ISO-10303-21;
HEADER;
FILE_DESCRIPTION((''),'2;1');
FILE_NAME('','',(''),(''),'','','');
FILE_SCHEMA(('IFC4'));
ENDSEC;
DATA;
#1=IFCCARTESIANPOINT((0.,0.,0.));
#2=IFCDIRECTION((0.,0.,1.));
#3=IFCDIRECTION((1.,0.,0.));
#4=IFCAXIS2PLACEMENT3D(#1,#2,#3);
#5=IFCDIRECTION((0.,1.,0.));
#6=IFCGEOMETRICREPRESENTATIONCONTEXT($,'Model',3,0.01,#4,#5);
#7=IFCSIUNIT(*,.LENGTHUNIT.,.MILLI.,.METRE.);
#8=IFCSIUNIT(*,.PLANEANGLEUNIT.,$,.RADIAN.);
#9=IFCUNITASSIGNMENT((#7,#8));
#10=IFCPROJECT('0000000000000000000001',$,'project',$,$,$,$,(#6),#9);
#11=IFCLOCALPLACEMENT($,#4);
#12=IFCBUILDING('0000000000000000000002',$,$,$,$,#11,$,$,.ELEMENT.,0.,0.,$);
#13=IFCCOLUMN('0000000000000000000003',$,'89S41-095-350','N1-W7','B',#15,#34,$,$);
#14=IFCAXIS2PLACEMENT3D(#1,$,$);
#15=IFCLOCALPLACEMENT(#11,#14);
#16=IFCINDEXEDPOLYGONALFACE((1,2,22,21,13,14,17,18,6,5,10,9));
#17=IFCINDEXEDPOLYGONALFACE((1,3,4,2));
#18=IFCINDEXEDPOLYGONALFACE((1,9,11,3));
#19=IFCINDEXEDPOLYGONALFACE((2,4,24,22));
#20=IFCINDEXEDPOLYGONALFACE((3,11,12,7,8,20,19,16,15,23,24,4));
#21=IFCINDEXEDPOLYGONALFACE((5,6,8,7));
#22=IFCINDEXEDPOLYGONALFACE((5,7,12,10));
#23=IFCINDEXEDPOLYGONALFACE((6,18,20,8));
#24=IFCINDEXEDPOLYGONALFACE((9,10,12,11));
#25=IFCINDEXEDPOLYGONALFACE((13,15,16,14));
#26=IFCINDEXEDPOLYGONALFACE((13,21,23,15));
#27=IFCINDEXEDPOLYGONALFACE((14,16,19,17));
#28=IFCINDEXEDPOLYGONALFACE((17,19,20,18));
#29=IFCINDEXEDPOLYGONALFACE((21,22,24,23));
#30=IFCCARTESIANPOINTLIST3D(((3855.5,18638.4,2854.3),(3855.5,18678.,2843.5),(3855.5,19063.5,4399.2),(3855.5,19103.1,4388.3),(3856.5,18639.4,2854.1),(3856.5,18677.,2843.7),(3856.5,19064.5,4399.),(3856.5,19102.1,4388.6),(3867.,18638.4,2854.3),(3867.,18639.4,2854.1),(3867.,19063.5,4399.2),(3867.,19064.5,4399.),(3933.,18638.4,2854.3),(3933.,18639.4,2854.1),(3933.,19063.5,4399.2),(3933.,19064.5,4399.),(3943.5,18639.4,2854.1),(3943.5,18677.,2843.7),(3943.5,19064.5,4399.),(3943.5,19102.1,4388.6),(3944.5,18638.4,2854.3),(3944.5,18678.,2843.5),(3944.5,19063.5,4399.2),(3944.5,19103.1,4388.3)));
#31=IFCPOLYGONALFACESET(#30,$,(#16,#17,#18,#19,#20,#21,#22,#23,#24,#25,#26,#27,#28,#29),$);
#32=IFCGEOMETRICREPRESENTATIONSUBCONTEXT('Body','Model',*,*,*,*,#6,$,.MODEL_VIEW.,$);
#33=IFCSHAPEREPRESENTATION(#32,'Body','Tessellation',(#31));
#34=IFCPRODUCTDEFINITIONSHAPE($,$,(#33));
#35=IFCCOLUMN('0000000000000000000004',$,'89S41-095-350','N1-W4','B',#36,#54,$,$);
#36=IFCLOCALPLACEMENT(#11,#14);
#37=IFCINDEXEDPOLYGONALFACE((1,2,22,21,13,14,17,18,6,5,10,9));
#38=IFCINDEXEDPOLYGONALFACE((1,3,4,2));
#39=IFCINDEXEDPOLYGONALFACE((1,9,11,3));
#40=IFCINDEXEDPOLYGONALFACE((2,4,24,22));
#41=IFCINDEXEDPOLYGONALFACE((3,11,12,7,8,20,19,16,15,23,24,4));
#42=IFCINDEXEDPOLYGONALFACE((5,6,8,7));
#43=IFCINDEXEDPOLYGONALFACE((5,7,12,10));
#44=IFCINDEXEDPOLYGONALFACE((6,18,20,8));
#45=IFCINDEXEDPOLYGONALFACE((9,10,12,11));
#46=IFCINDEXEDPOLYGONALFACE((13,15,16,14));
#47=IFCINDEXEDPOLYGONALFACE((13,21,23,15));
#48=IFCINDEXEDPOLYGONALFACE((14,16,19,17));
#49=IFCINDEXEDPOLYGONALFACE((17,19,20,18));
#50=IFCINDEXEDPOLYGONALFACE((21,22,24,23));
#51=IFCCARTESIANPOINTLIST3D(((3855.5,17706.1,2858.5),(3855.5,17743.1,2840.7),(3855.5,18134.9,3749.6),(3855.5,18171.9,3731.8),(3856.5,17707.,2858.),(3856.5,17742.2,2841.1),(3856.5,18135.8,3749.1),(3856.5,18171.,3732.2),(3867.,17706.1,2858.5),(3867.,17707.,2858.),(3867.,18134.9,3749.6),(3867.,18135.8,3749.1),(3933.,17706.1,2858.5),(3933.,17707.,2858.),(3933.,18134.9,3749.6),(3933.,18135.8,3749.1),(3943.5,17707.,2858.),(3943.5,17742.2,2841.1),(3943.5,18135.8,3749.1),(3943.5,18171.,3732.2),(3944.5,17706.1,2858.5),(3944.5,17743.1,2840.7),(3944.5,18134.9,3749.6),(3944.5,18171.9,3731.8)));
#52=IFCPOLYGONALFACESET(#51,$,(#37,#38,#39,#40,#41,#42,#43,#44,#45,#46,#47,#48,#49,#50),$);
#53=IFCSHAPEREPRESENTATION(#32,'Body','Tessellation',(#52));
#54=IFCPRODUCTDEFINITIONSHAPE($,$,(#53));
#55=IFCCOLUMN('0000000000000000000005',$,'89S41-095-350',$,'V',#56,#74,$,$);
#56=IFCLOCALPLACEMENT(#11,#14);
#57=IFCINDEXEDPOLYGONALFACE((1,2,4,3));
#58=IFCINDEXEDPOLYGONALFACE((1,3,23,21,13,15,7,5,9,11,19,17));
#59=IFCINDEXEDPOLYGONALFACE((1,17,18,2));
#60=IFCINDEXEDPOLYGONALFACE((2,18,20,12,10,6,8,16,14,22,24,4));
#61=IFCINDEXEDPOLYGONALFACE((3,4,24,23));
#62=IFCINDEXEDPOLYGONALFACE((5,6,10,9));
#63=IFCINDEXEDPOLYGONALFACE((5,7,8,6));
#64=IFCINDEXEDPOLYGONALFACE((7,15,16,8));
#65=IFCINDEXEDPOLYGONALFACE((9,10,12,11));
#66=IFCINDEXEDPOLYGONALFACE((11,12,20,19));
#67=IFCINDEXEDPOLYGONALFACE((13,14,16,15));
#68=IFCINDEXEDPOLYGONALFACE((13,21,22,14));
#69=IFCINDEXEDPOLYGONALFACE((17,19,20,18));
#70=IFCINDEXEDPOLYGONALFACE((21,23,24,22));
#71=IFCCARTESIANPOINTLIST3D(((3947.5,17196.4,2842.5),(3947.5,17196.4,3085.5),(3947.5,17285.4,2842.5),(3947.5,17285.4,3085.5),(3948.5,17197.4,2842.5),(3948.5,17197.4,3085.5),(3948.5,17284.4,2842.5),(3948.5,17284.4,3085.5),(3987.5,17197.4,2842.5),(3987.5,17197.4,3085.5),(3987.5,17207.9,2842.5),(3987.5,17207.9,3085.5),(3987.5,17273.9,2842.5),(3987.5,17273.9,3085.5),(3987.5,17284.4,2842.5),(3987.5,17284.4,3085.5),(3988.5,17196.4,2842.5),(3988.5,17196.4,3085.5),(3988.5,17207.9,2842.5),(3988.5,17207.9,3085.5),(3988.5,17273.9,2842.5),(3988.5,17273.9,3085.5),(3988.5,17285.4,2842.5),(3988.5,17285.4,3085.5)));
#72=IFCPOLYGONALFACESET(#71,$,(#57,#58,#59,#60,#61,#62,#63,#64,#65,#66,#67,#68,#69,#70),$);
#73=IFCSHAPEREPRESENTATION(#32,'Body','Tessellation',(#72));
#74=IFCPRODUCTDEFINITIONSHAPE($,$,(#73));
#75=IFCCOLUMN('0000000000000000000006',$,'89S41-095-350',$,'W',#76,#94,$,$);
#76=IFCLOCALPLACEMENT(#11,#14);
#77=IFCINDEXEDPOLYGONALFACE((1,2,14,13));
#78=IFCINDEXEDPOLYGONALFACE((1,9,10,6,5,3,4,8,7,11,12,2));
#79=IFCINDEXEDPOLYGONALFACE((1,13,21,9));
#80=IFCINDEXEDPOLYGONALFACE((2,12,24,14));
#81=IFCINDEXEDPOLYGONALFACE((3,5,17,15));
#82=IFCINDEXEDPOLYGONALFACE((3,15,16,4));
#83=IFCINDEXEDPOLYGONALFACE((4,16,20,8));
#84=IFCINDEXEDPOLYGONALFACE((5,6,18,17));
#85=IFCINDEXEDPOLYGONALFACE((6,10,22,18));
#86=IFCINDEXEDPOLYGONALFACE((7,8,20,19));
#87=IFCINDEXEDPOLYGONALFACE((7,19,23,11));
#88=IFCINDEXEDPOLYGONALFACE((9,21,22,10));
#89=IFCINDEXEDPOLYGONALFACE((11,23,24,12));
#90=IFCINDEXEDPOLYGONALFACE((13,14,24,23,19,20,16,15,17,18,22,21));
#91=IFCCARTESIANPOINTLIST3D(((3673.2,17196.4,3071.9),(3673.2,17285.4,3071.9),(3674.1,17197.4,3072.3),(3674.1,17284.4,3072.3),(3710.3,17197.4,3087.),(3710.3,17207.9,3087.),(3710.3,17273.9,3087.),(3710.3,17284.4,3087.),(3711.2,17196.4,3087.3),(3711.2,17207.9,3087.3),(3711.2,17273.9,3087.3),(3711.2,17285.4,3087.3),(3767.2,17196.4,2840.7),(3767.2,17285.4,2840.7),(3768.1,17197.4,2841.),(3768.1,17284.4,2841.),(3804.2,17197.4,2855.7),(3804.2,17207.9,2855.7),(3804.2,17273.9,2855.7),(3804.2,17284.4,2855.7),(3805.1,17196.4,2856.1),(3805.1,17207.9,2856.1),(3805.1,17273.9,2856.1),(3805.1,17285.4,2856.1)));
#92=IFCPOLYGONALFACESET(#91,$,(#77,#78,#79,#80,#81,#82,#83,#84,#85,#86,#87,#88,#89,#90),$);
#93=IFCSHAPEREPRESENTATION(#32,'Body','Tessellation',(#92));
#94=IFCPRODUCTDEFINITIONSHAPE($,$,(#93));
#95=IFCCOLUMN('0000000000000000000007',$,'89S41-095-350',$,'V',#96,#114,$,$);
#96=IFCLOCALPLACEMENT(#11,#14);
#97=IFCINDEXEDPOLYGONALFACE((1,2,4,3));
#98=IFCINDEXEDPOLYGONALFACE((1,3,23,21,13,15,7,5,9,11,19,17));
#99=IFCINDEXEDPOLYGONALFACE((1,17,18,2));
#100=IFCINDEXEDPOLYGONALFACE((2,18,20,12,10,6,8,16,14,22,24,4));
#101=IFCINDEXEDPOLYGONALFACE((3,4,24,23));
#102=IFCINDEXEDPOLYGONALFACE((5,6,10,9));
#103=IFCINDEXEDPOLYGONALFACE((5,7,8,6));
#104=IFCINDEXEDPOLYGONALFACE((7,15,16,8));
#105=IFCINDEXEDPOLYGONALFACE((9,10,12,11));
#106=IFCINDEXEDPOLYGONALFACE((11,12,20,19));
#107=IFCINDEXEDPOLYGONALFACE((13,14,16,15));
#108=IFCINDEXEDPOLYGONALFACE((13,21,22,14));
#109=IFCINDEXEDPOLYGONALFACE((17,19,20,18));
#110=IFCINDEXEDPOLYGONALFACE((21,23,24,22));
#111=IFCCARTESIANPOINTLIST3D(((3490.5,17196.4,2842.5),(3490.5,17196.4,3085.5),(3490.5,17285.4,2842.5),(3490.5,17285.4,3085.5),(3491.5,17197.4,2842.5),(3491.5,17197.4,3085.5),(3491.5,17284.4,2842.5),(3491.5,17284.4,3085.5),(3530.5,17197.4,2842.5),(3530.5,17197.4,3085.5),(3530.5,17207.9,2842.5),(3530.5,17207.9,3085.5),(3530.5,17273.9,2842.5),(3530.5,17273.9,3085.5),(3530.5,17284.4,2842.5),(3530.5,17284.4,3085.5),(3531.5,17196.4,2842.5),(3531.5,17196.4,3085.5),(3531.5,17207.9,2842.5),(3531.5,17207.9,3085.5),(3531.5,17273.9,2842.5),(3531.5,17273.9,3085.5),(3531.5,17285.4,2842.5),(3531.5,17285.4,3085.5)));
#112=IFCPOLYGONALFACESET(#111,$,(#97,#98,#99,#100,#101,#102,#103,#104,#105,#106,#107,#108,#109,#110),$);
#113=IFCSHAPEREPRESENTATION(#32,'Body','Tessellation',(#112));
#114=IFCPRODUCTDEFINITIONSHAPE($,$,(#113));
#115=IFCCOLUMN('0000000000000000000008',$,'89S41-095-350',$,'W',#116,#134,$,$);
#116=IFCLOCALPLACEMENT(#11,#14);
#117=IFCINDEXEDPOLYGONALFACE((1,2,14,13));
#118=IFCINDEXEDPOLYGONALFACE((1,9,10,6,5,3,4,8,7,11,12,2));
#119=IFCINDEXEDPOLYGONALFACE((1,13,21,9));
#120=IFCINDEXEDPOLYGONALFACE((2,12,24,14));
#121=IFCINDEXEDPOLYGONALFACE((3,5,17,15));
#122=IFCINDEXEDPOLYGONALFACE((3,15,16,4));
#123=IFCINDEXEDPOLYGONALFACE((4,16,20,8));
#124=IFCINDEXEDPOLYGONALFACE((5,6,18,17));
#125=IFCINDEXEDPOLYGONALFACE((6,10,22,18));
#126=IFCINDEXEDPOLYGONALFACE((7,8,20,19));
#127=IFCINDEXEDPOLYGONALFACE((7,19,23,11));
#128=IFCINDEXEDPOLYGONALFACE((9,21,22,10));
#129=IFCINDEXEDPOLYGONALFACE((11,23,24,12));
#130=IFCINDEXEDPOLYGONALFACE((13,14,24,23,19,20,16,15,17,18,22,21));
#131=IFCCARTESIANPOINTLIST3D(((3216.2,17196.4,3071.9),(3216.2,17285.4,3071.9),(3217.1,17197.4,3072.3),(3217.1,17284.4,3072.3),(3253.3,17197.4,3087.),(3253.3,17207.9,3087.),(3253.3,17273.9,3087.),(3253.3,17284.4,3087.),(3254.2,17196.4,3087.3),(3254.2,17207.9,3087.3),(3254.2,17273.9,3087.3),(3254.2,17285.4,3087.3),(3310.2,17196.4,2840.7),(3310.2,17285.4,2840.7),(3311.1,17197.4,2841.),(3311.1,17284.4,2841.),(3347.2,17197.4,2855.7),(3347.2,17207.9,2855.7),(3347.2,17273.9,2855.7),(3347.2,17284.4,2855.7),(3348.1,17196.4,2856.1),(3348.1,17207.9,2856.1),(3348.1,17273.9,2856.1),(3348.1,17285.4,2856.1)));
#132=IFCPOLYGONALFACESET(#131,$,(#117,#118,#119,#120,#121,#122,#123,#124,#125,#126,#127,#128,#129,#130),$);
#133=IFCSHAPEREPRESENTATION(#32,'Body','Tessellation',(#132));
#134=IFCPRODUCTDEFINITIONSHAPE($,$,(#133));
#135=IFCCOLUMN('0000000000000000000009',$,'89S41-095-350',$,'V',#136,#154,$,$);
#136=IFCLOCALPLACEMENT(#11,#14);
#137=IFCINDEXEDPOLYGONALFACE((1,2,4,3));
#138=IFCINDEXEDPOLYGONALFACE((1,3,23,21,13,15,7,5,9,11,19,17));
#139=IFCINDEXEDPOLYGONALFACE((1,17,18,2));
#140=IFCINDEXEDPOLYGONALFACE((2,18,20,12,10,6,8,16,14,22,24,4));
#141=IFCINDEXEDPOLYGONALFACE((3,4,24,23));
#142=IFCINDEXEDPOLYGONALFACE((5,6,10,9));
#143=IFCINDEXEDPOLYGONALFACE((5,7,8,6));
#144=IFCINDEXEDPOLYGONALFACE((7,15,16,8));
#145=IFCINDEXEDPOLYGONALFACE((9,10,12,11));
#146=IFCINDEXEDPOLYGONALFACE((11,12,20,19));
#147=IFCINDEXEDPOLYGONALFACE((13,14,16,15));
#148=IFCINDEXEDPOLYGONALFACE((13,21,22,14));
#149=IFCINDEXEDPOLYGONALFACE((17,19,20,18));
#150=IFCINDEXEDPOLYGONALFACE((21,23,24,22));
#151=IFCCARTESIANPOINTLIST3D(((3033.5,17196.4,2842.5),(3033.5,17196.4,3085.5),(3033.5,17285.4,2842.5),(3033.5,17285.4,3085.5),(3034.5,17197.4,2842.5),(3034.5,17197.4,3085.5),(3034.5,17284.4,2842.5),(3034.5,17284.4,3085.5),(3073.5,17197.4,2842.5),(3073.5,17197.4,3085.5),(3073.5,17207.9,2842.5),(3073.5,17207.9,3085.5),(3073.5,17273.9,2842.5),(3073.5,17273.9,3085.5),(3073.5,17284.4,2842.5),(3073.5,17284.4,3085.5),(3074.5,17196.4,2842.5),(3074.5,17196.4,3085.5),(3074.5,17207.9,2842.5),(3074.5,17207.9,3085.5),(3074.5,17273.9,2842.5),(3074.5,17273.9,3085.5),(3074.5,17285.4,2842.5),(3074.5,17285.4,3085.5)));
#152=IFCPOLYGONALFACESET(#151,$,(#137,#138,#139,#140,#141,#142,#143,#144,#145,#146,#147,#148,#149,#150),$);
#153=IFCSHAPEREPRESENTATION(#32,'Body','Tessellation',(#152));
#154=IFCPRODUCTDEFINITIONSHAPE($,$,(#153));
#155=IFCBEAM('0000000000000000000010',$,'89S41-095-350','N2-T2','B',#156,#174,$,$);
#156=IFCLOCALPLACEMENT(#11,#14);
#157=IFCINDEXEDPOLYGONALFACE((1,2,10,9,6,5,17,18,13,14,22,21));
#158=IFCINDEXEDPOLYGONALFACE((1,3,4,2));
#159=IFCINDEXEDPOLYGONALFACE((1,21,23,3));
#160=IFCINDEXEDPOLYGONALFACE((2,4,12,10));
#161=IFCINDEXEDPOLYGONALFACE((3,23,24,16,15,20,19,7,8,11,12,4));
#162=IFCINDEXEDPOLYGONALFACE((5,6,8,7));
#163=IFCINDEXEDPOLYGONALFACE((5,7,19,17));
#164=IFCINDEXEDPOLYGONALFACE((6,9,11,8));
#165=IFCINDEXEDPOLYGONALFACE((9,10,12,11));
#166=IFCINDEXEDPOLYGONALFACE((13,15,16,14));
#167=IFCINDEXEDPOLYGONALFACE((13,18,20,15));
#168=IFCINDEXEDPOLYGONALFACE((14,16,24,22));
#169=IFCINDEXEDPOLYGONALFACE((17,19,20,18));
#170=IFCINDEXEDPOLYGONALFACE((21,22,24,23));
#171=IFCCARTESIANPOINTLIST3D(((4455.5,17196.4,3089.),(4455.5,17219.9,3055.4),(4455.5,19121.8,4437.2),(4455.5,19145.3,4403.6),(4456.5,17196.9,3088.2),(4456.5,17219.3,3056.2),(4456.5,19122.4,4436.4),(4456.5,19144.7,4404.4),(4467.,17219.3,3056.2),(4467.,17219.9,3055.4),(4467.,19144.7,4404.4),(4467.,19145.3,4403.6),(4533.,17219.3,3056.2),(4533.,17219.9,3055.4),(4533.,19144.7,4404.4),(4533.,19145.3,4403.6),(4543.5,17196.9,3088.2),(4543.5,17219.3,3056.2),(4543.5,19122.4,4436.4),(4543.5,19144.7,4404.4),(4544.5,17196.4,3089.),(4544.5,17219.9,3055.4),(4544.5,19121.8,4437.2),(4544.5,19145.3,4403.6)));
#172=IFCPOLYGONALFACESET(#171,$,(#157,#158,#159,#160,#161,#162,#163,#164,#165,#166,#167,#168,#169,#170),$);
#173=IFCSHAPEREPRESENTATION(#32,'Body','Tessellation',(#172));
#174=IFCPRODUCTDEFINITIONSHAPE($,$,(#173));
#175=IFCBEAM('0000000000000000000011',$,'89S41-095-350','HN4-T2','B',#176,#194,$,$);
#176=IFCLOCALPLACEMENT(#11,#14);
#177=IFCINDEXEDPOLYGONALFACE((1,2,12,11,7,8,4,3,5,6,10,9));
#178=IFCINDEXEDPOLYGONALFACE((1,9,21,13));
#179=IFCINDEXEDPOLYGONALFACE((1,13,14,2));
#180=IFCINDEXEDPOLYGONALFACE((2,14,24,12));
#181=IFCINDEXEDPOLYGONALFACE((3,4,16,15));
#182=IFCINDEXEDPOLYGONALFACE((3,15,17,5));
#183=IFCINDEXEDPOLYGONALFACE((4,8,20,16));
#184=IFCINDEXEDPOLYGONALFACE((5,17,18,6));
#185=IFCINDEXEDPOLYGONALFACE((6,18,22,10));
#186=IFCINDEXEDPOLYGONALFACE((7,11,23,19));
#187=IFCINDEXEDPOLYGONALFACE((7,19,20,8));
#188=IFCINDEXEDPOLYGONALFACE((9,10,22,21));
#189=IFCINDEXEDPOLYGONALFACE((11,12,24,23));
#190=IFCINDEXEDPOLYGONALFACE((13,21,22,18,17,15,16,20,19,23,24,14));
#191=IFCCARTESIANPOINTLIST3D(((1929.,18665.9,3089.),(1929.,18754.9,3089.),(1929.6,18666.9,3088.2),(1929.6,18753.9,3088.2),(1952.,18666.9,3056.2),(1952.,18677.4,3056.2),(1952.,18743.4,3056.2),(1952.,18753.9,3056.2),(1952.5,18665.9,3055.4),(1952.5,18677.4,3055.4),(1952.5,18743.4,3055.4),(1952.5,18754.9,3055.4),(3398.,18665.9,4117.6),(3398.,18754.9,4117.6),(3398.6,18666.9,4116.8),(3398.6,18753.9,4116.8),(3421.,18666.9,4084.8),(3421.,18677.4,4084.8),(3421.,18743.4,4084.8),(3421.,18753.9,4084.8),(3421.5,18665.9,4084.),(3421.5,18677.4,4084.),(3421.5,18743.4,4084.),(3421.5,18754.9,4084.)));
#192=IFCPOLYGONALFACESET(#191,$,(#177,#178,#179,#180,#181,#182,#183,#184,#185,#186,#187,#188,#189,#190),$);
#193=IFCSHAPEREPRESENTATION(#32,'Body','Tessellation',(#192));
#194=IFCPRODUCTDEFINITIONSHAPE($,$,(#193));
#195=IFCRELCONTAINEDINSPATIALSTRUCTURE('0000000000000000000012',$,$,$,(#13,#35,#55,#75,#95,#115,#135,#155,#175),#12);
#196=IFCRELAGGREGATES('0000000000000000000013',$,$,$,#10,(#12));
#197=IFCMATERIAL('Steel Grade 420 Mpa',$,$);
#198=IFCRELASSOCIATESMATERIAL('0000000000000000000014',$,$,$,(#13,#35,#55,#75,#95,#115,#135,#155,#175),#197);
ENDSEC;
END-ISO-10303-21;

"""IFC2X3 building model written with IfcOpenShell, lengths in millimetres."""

from ifc_helpers import new_model, si_unit, direction, frame, origin, origin_with_axes, origin_2d_with_axis, place, context, subcontext, project, spatial, c_section, extrude, source, transform, mapped, material, element, save


model = new_model("IFC2X3")

# Units and contexts
model_context = context("Model", 3, precision=0.01, world=origin_with_axes(), true_north=direction((0.0, 1.0, 0.0)))
body_context = subcontext(model_context, "Body", "Model", "MODEL_VIEW")
ifc_project = project(units=[si_unit("LENGTHUNIT", "METRE", prefix="MILLI"), si_unit("PLANEANGLEUNIT", "RADIAN")], contexts=[model_context])

# Building
building_placement = place(None, origin_with_axes())
building = spatial("IfcBuilding", under=ifc_project, at=building_placement, CompositionType="ELEMENT", ElevationOfRefHeight=0.0, ElevationOfTerrain=0.0)

# Columns
ifc_material = material(Name="Steel Grade 420 Mpa")
shared_shape_1 = source(origin(), body_context, "Body", "SweptSolid", [
    extrude(c_section(Depth=89.0, Width=41.0, WallThickness=1.0, Girth=11.5, at=origin_2d_with_axis()), origin_with_axes(), (0.0, 0.0, 1.0), 1602.3),
])
column_1_placement = place(None, frame((3900.0, 19083.3, 4393.8), z_axis=(0.0, -0.265305, -0.964165), x_axis=(0.0, -0.964165, 0.265305)))
element("IfcColumn", 1, at=column_1_placement, inside=building, material=ifc_material, Name="89S41-095-350", Description="N1-W7", ObjectType="B", context=body_context, shape_type="MappedRepresentation", body=[
    mapped(shared_shape_1, transform((0.0, 0.0, 0.0), scale=1.0)),
])
shared_shape_2 = source(origin(), body_context, "Body", "SweptSolid", [
    extrude(c_section(Depth=89.0, Width=41.0, WallThickness=1.0, Girth=11.5, at=origin_2d_with_axis()), origin_with_axes(), (0.0, 0.0, 1.0), 988.9),
])
column_2_placement = place(None, frame((3900.0, 18153.4, 3740.7), z_axis=(0.0, -0.433624, -0.901094), x_axis=(0.0, -0.901094, 0.433624)))
element("IfcColumn", 2, at=column_2_placement, inside=building, material=ifc_material, Name="89S41-095-350", Description="N1-W4", ObjectType="B", context=body_context, shape_type="MappedRepresentation", body=[
    mapped(shared_shape_2, transform((0.0, 0.0, 0.0), scale=1.0)),
])
shared_shape_3 = source(origin(), body_context, "Body", "SweptSolid", [
    extrude(c_section(Depth=89.0, Width=41.0, WallThickness=1.0, Girth=11.5, at=origin_2d_with_axis()), origin_with_axes(), (0.0, 0.0, 1.0), 243.0),
])
column_3_placement = place(None, frame((3968.0, 17240.9, 3085.5), z_axis=(0.0, 0.0, -1.0), x_axis=(1.0, 0.0, 0.0)))
element("IfcColumn", 3, at=column_3_placement, inside=building, material=ifc_material, Name="89S41-095-350", ObjectType="V", context=body_context, shape_type="MappedRepresentation", body=[
    mapped(shared_shape_3, transform((0.0, 0.0, 0.0), scale=1.0)),
])
shared_shape_4 = source(origin(), body_context, "Body", "SweptSolid", [
    extrude(c_section(Depth=89.0, Width=41.0, WallThickness=1.0, Girth=11.5, at=origin_2d_with_axis()), origin_with_axes(), (0.0, 0.0, 1.0), 249.6),
])
column_4_placement = place(None, frame((3692.2, 17240.9, 3079.6), z_axis=(0.376416, 0.0, -0.926451), x_axis=(0.926451, 0.0, 0.376416)))
element("IfcColumn", 4, at=column_4_placement, inside=building, material=ifc_material, Name="89S41-095-350", ObjectType="W", context=body_context, shape_type="MappedRepresentation", body=[
    mapped(shared_shape_4, transform((0.0, 0.0, 0.0), scale=1.0)),
])
shared_shape_5 = source(origin(), body_context, "Body", "SweptSolid", [
    extrude(c_section(Depth=89.0, Width=41.0, WallThickness=1.0, Girth=11.5, at=origin_2d_with_axis()), origin_with_axes(), (0.0, 0.0, 1.0), 243.0),
])
column_5_placement = place(None, frame((3511.0, 17240.9, 3085.5), z_axis=(0.0, 0.0, -1.0), x_axis=(1.0, 0.0, 0.0)))
element("IfcColumn", 5, at=column_5_placement, inside=building, material=ifc_material, Name="89S41-095-350", ObjectType="V", context=body_context, shape_type="MappedRepresentation", body=[
    mapped(shared_shape_5, transform((0.0, 0.0, 0.0), scale=1.0)),
])
shared_shape_6 = source(origin(), body_context, "Body", "SweptSolid", [
    extrude(c_section(Depth=89.0, Width=41.0, WallThickness=1.0, Girth=11.5, at=origin_2d_with_axis()), origin_with_axes(), (0.0, 0.0, 1.0), 249.6),
])
column_6_placement = place(None, frame((3235.2, 17240.9, 3079.6), z_axis=(0.376416, 0.0, -0.926451), x_axis=(0.926451, 0.0, 0.376416)))
element("IfcColumn", 6, at=column_6_placement, inside=building, material=ifc_material, Name="89S41-095-350", ObjectType="W", context=body_context, shape_type="MappedRepresentation", body=[
    mapped(shared_shape_6, transform((0.0, 0.0, 0.0), scale=1.0)),
])
shared_shape_7 = source(origin(), body_context, "Body", "SweptSolid", [
    extrude(c_section(Depth=89.0, Width=41.0, WallThickness=1.0, Girth=11.5, at=origin_2d_with_axis()), origin_with_axes(), (0.0, 0.0, 1.0), 243.0),
])
column_7_placement = place(None, frame((3054.0, 17240.9, 3085.5), z_axis=(0.0, 0.0, -1.0), x_axis=(1.0, 0.0, 0.0)))
element("IfcColumn", 7, at=column_7_placement, inside=building, material=ifc_material, Name="89S41-095-350", ObjectType="V", context=body_context, shape_type="MappedRepresentation", body=[
    mapped(shared_shape_7, transform((0.0, 0.0, 0.0), scale=1.0)),
])

# Beams
shared_shape_8 = source(origin(), body_context, "Body", "SweptSolid", [
    extrude(c_section(Depth=89.0, Width=41.0, WallThickness=1.0, Girth=11.5, at=origin_2d_with_axis()), origin_with_axes(), (0.0, 0.0, 1.0), 2350.5),
])
beam_1_placement = place(None, frame((4500.0, 17208.1, 3072.2), z_axis=(0.0, 0.819152, 0.573576), x_axis=(0.0, 0.573576, -0.819152)))
element("IfcBeam", 8, at=beam_1_placement, inside=building, material=ifc_material, Name="89S41-095-350", Description="N2-T2", ObjectType="B", context=body_context, shape_type="MappedRepresentation", body=[
    mapped(shared_shape_8, transform((0.0, 0.0, 0.0), scale=1.0)),
])
shared_shape_9 = source(origin(), body_context, "Body", "SweptSolid", [
    extrude(c_section(Depth=89.0, Width=41.0, WallThickness=1.0, Girth=11.5, at=origin_2d_with_axis()), origin_with_axes(), (0.0, 0.0, 1.0), 1793.3),
])
beam_2_placement = place(None, frame((3409.8, 18710.4, 4100.8), z_axis=(-0.819152, 0.0, -0.573576), x_axis=(0.573576, 0.0, -0.819152)))
element("IfcBeam", 9, at=beam_2_placement, inside=building, material=ifc_material, Name="89S41-095-350", Description="HN4-T2", ObjectType="B", context=body_context, shape_type="MappedRepresentation", body=[
    mapped(shared_shape_9, transform((0.0, 0.0, 0.0), scale=1.0)),
])

save(model, "model.ifc")
